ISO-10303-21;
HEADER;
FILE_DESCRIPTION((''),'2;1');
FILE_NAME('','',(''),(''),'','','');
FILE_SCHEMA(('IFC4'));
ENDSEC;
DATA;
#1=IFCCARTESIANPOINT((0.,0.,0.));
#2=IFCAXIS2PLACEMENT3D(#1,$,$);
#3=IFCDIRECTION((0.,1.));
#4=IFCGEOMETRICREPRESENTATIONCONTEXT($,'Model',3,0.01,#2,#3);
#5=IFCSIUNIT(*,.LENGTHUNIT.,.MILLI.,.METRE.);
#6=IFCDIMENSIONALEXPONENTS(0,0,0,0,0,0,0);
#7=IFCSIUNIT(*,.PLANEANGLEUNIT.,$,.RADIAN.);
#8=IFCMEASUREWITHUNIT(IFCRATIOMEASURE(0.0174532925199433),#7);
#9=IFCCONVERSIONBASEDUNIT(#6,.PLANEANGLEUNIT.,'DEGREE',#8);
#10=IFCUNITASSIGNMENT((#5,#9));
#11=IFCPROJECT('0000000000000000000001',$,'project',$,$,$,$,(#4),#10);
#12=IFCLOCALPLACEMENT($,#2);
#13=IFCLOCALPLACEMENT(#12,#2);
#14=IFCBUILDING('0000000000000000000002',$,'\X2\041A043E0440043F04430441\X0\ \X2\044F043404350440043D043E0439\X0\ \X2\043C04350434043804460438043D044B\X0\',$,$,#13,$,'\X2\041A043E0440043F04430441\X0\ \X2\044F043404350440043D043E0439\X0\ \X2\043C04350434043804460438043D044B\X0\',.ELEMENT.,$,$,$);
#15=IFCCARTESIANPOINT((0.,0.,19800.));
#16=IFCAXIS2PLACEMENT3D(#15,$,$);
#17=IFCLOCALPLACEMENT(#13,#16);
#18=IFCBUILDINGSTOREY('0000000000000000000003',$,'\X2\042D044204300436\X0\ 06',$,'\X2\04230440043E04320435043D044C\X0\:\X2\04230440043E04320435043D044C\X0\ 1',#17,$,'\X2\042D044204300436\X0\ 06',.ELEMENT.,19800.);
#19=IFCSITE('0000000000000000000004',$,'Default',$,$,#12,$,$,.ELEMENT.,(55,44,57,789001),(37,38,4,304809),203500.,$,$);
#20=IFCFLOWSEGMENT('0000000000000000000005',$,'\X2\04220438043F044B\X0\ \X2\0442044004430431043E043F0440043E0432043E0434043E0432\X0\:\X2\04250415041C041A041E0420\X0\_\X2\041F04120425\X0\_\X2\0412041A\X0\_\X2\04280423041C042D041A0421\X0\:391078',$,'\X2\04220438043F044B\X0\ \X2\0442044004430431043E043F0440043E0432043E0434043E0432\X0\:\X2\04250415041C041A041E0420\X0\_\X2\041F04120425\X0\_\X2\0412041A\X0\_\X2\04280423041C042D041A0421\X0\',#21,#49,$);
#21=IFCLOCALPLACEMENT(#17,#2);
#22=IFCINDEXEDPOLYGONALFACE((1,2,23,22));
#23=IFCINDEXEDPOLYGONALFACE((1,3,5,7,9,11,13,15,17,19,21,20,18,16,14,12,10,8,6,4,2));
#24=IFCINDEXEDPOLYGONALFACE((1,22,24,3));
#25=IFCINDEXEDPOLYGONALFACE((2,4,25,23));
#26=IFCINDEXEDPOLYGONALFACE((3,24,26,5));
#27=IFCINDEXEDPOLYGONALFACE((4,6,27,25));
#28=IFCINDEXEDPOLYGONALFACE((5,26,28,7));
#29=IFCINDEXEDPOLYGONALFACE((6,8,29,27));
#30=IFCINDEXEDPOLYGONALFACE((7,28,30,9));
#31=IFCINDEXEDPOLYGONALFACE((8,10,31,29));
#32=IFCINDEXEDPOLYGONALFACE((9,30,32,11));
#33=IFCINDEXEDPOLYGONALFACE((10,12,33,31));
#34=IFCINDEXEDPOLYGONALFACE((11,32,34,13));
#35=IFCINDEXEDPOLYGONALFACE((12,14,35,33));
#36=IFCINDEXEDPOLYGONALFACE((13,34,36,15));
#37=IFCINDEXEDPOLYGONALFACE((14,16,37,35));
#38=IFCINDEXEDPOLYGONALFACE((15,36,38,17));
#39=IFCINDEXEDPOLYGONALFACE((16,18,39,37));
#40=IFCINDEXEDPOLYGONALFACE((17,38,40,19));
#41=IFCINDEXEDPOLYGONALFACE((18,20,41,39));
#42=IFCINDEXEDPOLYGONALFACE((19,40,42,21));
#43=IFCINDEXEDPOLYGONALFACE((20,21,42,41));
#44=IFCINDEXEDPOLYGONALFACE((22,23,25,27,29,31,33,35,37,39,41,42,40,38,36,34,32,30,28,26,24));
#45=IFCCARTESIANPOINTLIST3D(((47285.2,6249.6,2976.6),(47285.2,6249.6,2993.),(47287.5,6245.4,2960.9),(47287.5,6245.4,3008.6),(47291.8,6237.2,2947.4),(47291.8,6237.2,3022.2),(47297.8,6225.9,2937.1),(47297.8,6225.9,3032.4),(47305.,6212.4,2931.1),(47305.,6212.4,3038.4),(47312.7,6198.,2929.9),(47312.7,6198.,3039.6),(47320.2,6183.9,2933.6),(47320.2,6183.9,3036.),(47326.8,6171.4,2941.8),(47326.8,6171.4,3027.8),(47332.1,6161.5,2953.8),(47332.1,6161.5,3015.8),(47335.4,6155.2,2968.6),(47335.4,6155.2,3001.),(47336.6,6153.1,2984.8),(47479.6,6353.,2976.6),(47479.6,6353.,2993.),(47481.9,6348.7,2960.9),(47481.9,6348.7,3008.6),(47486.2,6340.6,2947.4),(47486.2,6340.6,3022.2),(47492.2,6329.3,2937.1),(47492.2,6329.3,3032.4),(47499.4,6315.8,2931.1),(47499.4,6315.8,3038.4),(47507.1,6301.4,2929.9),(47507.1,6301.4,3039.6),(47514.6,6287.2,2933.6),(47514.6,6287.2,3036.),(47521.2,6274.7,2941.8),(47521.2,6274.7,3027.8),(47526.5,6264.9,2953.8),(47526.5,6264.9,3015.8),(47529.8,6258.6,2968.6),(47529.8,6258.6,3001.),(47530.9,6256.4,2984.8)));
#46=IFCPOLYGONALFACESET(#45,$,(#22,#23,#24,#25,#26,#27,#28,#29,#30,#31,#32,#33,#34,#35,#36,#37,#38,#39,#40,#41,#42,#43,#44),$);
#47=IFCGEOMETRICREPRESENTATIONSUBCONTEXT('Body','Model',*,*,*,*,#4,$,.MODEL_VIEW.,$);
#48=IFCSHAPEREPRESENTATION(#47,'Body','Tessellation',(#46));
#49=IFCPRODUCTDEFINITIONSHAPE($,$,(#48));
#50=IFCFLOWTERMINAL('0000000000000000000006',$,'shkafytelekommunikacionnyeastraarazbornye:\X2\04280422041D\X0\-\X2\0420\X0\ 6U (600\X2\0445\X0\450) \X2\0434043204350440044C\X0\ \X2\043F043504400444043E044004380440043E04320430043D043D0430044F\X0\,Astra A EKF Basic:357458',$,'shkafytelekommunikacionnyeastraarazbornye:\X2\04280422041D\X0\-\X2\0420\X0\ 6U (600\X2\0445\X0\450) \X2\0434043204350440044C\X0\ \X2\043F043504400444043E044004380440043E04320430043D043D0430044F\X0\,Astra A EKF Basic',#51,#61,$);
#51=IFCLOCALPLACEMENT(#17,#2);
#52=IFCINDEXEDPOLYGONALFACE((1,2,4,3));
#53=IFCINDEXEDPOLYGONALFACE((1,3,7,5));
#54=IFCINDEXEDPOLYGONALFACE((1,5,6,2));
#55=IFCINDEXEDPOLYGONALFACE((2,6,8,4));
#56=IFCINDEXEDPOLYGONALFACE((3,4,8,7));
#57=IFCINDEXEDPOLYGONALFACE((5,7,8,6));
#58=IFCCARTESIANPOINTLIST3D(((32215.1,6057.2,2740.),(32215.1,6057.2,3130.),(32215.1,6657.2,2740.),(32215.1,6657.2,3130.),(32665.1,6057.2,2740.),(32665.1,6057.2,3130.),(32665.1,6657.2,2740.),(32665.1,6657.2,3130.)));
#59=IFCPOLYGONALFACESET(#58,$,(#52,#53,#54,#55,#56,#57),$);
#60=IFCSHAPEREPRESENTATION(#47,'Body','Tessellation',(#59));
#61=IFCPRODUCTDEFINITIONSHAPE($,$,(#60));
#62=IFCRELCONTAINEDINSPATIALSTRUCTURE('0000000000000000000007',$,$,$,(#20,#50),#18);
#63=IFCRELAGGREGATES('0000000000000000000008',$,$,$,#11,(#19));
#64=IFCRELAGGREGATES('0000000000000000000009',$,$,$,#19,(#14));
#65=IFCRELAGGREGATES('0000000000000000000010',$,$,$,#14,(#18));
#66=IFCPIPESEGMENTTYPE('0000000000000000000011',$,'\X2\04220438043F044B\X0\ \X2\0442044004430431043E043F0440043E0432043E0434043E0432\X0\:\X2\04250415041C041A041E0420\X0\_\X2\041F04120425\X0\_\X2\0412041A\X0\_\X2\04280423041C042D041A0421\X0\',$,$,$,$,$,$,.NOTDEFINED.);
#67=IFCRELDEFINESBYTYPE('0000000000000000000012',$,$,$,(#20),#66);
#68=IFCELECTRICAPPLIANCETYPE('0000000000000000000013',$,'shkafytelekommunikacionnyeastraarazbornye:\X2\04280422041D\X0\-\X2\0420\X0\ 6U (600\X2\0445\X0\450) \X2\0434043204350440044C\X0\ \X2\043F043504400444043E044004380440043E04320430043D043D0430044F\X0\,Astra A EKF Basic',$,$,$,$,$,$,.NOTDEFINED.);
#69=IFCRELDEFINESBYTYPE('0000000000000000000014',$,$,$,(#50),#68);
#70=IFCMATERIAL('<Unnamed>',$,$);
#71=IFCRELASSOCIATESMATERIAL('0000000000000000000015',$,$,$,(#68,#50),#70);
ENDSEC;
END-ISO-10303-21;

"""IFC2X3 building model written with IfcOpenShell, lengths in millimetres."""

from ifc_helpers import new_model, entity, si_unit, converted_unit, direction, frame, origin, origin_2d_with_axis, place, context, subcontext, project, spatial, rectangle, circle, extrude, source, transform, mapped, material, type_object, type_shapes, element, save


model = new_model("IFC2X3")

# Units and contexts
model_context = context("Model", 3, precision=0.01, world=origin(), true_north=direction((0.0, 1.0)))
body_context = subcontext(model_context, "Body", "Model", "MODEL_VIEW")
ifc_project = project(units=[si_unit("LENGTHUNIT", "METRE", prefix="MILLI"), converted_unit("PLANEANGLEUNIT", "DEGREE", entity("IfcRatioMeasure", 0.0174532925199433), si_unit("PLANEANGLEUNIT", "RADIAN"), dimensions=[0, 0, 0, 0, 0, 0, 0])], contexts=[model_context])

# Site, building, storey
site_placement = place(None, origin())
site = spatial("IfcSite", under=ifc_project, at=site_placement, Name="Default", CompositionType="ELEMENT", RefLatitude=(55, 44, 57, 789001), RefLongitude=(37, 38, 4, 304809), RefElevation=203500.0)
building_placement = place(site_placement, origin())
building = spatial("IfcBuilding", under=site, at=building_placement, Name="Корпус ядерной медицины", LongName="Корпус ядерной медицины", CompositionType="ELEMENT")
storey_placement = place(building_placement, frame((0.0, 0.0, 19800.0)))
storey = spatial("IfcBuildingStorey", under=building, at=storey_placement, Name="Этаж 06", ObjectType="Уровень:Уровень 1", LongName="Этаж 06", CompositionType="ELEMENT", Elevation=19800.0)

# Flow segment
pipe_segment_type = type_object("IfcPipeSegmentType", Name="Типы трубопроводов:ХЕМКОР_ПВХ_ВК_ШУМЭКС", PredefinedType="NOTDEFINED")
flow_segment_1_placement = place(storey_placement, frame((47283.3, 6151.5, 2928.2)))
element("IfcFlowSegment", 1, at=flow_segment_1_placement, inside=storey, type_object=pipe_segment_type, Name="Типы трубопроводов:ХЕМКОР_ПВХ_ВК_ШУМЭКС:391078", ObjectType="Типы трубопроводов:ХЕМКОР_ПВХ_ВК_ШУМЭКС", context=body_context, shape_type="SweptSolid", body=[
    extrude(circle(Radius=55.0, at=origin_2d_with_axis()), frame((27.4, 50.2, 56.6), z_axis=(0.882948, 0.469472, 0.0), x_axis=(0.469472, -0.882948, 0.0)), (0.0, 0.0, 1.0), 220.1),
])

# Flow terminal
ifc_material = material(Name="<Unnamed>")
electric_appliance_type = type_object("IfcElectricApplianceType", Name="shkafytelekommunikacionnyeastraarazbornye:ШТН-Р 6U (600х450) дверь перфорированная,Astra A EKF Basic", PredefinedType="TELEPHONE", material=ifc_material)
shared_shape = source(origin(), body_context, "Body", "SweptSolid", [
    extrude(rectangle(XDim=600.0, YDim=450.0, at=origin_2d_with_axis()), frame((0.0, 0.0, 0.0), z_axis=(0.0, 0.0, 1.0), x_axis=(-1.0, 0.0, 0.0)), (0.0, 0.0, 1.0), 390.0),
])
type_shapes(electric_appliance_type, [shared_shape])
flow_terminal_placement = place(storey_placement, frame((32440.1, 6357.2, 2740.0), z_axis=(0.0, 0.0, 1.0), x_axis=(0.0, 1.0, 0.0)))
element("IfcFlowTerminal", 2, at=flow_terminal_placement, inside=storey, type_object=electric_appliance_type, material=ifc_material, Name="shkafytelekommunikacionnyeastraarazbornye:ШТН-Р 6U (600х450) дверь перфорированная,Astra A EKF Basic:357458", ObjectType="shkafytelekommunikacionnyeastraarazbornye:ШТН-Р 6U (600х450) дверь перфорированная,Astra A EKF Basic", context=body_context, shape_type="MappedRepresentation", body=[
    mapped(shared_shape, transform((0.0, 0.0, 0.0), scale=1.0)),
])

save(model, "model.ifc")
